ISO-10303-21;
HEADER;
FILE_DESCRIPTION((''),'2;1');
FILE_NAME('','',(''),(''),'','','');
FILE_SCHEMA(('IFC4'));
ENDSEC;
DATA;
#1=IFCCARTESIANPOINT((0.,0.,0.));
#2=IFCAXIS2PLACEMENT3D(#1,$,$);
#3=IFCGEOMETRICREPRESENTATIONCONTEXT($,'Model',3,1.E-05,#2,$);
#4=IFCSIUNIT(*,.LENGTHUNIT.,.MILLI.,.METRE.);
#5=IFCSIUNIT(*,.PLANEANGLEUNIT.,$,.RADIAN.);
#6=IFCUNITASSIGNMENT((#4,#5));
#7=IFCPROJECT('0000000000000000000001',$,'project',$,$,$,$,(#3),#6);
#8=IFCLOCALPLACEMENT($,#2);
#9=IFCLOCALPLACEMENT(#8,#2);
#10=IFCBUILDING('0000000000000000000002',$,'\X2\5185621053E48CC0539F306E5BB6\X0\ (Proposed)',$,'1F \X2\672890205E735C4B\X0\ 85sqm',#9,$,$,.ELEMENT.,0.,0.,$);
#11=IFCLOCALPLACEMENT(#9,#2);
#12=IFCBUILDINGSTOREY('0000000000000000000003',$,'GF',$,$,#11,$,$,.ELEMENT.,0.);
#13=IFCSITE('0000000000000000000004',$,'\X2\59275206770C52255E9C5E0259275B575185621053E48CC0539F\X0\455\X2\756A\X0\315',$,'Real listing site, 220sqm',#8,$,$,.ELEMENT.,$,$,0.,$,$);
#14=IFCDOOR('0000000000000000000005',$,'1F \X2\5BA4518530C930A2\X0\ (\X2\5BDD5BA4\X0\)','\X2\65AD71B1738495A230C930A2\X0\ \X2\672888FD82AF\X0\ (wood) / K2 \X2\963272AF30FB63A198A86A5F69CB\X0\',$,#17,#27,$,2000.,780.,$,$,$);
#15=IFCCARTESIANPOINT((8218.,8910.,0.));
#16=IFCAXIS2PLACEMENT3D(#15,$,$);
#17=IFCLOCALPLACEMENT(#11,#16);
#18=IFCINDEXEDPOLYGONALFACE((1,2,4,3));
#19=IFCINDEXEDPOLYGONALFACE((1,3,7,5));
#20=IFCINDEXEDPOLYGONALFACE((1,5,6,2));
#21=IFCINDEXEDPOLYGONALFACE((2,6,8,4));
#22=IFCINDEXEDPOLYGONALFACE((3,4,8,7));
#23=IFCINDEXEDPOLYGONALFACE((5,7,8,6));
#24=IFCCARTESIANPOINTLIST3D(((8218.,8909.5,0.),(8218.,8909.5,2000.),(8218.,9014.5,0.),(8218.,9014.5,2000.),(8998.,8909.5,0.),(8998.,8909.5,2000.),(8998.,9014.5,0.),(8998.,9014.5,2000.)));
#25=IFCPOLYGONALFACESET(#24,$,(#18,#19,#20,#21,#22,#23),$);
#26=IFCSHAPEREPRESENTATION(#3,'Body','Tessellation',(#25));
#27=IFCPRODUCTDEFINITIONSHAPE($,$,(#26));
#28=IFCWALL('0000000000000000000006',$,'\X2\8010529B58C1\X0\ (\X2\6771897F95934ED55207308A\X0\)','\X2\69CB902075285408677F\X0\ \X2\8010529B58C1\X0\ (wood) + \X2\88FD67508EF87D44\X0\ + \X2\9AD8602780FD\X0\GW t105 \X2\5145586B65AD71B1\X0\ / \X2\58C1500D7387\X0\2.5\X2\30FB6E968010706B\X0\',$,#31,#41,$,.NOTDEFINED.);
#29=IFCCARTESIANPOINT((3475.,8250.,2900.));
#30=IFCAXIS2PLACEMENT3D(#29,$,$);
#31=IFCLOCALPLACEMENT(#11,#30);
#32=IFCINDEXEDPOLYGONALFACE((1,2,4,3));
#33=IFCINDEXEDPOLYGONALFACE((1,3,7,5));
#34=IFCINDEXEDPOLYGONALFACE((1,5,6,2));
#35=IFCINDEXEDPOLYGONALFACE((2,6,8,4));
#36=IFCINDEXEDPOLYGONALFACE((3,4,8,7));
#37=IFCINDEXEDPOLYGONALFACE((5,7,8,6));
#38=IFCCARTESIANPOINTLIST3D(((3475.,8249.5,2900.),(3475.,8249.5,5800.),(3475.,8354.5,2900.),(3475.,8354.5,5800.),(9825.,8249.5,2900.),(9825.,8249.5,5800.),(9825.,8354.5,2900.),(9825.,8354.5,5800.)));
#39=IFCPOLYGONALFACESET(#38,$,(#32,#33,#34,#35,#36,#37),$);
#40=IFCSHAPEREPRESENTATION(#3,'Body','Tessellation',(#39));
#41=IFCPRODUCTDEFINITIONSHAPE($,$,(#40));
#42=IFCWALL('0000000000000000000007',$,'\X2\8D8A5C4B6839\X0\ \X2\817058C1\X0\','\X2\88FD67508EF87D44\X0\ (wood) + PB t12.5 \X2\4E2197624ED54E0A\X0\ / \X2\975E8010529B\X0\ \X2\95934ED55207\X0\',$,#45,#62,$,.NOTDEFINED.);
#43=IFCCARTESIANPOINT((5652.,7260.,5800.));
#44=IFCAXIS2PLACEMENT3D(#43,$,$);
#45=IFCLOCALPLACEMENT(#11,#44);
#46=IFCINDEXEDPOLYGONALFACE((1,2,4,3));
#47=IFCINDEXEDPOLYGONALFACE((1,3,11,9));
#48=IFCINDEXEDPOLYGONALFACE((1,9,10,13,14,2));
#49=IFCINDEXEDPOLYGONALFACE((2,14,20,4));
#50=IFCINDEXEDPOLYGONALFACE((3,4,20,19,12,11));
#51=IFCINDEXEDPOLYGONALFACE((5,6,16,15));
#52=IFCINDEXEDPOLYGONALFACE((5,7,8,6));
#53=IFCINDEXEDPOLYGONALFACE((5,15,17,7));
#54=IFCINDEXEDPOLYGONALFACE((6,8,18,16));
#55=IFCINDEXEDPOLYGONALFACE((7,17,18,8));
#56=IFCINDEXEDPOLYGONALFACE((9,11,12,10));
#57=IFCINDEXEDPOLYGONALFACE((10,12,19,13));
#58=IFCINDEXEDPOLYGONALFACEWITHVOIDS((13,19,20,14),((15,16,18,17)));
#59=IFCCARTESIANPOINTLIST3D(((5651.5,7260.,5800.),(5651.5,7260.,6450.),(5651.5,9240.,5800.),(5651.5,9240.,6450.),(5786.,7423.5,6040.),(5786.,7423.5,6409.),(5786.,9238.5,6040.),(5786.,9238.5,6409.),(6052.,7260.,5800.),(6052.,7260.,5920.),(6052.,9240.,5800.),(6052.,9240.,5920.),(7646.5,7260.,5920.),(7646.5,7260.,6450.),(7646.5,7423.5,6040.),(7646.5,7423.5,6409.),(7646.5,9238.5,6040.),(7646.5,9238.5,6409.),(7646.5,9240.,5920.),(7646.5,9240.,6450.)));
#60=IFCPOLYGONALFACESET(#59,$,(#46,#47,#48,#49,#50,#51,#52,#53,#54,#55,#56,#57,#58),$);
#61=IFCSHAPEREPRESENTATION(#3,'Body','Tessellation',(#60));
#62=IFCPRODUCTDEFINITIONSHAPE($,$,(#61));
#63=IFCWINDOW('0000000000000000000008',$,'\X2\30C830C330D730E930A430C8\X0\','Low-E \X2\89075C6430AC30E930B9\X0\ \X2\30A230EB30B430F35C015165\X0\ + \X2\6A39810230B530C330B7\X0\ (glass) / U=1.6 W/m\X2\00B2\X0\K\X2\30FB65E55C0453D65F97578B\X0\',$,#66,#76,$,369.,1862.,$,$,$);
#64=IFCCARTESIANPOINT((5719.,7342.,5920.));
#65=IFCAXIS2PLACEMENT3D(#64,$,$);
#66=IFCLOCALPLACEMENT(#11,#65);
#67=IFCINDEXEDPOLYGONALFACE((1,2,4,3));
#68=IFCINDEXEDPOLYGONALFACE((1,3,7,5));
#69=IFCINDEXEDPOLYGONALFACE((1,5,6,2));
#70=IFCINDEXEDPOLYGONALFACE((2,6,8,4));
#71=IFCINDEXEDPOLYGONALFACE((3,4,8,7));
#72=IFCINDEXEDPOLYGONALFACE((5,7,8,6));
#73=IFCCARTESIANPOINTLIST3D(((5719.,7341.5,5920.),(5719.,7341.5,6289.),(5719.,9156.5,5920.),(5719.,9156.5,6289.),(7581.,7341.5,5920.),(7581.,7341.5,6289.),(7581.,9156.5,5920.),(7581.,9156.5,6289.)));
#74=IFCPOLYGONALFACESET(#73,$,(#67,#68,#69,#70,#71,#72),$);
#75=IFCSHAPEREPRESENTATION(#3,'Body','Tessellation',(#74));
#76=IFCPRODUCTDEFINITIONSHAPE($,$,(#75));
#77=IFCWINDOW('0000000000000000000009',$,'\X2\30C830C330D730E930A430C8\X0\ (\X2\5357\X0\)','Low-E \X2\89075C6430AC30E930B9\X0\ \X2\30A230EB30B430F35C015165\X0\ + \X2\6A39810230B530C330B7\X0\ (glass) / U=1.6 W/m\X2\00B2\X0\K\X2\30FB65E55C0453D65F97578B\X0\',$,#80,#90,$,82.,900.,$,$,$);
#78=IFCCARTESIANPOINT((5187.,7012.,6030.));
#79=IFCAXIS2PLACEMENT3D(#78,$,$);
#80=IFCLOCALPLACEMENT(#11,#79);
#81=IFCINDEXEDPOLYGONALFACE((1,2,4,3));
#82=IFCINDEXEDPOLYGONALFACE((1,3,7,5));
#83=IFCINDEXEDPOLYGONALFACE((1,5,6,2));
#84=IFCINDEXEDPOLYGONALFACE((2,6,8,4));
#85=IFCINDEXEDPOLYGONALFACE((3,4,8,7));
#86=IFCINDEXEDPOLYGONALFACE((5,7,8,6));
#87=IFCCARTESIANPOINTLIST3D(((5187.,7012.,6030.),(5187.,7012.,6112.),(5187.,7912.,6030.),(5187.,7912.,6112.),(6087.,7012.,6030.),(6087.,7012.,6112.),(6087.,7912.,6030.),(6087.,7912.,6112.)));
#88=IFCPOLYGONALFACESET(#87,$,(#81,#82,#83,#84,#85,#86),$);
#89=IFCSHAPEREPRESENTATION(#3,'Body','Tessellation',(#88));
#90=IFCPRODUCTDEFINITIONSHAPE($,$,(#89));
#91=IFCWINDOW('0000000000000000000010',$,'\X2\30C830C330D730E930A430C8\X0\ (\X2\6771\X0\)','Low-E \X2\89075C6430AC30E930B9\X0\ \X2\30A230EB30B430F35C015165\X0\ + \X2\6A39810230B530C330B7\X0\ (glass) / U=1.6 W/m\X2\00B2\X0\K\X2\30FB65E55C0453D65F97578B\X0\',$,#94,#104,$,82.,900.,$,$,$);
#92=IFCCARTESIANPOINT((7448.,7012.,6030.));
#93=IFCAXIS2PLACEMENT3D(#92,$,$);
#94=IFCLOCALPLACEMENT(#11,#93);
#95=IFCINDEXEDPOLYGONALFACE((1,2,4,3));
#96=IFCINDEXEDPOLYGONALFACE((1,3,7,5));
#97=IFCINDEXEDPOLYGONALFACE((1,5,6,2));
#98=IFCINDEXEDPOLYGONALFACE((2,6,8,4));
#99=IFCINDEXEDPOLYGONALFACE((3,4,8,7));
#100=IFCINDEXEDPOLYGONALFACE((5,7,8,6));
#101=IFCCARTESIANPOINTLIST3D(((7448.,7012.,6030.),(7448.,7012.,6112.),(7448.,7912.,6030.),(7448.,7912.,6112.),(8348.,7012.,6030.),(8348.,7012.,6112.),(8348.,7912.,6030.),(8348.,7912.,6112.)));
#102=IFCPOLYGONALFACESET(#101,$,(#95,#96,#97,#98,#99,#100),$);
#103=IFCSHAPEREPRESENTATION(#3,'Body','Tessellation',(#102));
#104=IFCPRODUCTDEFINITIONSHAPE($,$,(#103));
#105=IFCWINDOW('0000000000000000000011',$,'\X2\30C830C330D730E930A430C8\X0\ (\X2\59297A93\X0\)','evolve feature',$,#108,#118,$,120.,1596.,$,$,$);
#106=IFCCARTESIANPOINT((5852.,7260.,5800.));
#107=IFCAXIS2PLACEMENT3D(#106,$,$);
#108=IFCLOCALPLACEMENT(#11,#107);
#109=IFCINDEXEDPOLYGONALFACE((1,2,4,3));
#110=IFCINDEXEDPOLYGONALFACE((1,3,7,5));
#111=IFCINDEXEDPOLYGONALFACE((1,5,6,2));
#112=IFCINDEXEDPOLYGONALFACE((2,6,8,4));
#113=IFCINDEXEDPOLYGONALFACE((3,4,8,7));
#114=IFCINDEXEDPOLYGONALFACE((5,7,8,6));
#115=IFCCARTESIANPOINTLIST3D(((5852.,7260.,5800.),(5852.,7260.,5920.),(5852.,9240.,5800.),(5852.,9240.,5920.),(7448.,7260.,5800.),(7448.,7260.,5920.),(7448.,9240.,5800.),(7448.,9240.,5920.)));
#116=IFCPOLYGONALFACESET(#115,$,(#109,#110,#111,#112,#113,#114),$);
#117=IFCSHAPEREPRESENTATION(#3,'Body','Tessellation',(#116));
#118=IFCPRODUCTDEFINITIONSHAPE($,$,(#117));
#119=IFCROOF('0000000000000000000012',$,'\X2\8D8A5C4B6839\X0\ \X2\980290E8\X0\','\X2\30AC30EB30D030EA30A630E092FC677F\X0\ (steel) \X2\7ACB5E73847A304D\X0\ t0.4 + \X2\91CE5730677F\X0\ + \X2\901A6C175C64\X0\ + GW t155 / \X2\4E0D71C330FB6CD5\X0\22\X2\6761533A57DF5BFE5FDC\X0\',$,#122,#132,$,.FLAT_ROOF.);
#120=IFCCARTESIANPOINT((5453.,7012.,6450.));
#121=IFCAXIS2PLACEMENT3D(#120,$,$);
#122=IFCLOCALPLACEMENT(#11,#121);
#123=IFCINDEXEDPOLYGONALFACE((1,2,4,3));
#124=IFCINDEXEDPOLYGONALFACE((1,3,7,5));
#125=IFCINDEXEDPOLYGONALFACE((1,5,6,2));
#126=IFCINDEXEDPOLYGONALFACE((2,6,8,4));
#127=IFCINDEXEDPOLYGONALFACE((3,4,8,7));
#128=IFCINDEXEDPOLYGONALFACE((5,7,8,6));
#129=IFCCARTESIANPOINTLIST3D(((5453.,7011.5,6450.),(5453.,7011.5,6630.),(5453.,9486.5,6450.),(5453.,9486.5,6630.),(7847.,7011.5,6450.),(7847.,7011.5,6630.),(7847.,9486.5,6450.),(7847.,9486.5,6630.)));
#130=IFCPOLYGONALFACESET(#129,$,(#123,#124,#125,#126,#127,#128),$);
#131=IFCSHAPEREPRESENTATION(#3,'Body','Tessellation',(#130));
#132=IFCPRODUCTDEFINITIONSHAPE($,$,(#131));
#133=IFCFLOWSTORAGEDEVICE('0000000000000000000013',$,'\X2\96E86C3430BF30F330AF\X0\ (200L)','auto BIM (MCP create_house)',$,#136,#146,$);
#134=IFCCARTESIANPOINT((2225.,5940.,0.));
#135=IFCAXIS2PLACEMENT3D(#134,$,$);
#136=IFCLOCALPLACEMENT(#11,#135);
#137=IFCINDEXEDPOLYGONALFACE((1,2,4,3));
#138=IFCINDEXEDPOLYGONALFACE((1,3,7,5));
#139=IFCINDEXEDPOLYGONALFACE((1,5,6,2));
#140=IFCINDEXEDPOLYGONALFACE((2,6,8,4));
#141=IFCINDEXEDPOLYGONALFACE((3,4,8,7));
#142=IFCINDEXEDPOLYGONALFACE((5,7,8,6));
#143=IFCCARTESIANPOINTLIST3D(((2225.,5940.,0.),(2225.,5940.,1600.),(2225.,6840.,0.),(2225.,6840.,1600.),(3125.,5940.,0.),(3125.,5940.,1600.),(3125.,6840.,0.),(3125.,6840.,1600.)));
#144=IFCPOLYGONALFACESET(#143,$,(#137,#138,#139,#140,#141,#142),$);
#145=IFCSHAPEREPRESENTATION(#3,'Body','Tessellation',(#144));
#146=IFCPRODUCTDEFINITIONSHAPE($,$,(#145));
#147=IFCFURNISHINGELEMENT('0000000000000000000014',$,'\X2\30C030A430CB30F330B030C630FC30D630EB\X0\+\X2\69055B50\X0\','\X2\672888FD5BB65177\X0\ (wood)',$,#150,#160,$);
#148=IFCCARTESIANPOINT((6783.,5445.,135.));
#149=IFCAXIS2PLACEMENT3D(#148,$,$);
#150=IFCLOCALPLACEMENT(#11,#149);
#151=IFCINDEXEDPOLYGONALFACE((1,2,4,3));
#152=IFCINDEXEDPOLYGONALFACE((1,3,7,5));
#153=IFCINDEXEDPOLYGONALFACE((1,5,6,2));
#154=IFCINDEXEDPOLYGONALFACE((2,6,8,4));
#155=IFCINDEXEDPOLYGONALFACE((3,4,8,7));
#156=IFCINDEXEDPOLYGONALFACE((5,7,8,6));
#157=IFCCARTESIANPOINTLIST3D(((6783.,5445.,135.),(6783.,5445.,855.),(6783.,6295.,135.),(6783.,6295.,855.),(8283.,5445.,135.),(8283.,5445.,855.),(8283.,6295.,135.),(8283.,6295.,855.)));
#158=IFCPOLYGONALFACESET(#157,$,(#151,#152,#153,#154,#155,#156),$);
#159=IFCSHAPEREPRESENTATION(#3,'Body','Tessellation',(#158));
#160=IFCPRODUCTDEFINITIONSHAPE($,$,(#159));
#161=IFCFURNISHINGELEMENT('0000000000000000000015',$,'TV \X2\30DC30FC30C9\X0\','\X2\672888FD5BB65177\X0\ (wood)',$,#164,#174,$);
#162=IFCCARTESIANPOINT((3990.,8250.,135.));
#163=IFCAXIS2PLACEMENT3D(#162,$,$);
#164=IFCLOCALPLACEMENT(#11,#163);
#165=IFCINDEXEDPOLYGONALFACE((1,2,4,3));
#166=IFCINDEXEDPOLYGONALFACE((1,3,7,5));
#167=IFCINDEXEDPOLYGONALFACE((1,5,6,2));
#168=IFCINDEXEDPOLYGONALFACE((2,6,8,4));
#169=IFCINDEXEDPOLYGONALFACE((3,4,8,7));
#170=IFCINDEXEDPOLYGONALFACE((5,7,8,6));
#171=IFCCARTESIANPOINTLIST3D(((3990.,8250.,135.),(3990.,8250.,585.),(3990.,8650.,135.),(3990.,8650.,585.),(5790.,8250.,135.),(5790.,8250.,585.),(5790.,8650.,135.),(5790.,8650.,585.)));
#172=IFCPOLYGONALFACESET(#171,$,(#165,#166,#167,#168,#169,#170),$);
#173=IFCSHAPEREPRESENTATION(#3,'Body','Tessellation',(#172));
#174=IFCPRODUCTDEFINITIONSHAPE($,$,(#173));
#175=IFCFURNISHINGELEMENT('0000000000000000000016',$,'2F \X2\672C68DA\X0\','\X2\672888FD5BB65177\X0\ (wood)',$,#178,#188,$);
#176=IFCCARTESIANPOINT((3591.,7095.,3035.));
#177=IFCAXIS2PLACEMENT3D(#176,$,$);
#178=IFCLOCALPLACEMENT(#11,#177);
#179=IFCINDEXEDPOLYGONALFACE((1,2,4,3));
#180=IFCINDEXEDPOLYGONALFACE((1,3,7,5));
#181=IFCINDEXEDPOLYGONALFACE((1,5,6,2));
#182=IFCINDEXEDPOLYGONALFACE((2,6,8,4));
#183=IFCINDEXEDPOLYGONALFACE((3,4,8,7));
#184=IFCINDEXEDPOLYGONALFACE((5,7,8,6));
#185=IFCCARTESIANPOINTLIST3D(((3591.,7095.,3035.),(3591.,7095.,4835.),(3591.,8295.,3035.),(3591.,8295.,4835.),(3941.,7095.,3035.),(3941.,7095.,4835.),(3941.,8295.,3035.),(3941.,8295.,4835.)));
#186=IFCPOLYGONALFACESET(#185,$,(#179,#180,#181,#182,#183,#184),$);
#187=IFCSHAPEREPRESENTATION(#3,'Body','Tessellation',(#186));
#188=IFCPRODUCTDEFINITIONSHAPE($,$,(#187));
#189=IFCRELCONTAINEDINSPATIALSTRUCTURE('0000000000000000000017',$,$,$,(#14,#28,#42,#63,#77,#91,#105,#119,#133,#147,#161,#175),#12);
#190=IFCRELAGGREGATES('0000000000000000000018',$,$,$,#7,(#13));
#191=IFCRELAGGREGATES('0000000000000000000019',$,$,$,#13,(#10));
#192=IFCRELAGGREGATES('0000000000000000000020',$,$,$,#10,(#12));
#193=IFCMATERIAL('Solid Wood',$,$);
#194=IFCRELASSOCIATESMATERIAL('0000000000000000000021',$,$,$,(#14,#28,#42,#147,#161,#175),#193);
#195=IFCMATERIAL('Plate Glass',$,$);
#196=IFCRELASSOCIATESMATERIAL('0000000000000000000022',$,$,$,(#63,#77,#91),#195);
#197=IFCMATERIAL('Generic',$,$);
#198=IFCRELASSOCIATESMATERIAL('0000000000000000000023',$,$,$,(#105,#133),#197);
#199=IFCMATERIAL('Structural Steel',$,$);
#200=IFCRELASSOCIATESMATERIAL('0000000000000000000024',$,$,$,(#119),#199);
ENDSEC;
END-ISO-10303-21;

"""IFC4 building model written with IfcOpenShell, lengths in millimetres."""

from ifc_helpers import new_model, si_unit, frame, frame_2d, origin, place, context, project, spatial, rectangle, extrude, material, element, fill, save


model = new_model("IFC4")

# Units and contexts
model_context = context("Model", 3, precision=1e-05, world=origin())
ifc_project = project(units=[si_unit("LENGTHUNIT", "METRE", prefix="MILLI"), si_unit("PLANEANGLEUNIT", "RADIAN")], contexts=[model_context])

# Site, building, storey
site_placement = place(None, origin())
site = spatial("IfcSite", under=ifc_project, at=site_placement, Name="大分県別府市大字内成古賀原455番315", ObjectType="Real listing site, 220sqm", CompositionType="ELEMENT", RefElevation=0.0)
building_placement = place(site_placement, origin())
building = spatial("IfcBuilding", under=site, at=building_placement, Name="内成古賀原の家 (Proposed)", ObjectType="1F 木造平屋 85sqm", CompositionType="ELEMENT", ElevationOfRefHeight=0.0, ElevationOfTerrain=0.0)
storey_placement = place(building_placement, origin())
storey = spatial("IfcBuildingStorey", under=building, at=storey_placement, Name="GF", CompositionType="ELEMENT", Elevation=0.0)

# Shared definitions
ifc_material_1 = material(Name="Solid Wood")

# Door
door_placement = place(storey_placement, frame((8218.0, 8910.0, 0.0)))
element("IfcDoor", 1, at=door_placement, inside=storey, material=ifc_material_1, Name="1F 室内ドア (寝室)", Description="断熱玄関ドア 木製芯 (wood) / K2 防犯・採風機構", OverallHeight=2000.0, OverallWidth=780.0, context=model_context, shape_type="SweptSolid", body=[
    extrude(rectangle(XDim=780.0, YDim=105.0, at=frame_2d((390.0, 52.0))), frame((8218.0, 8910.0, 0.0)), (0.0, 0.0, 1.0), 2000.0),
])

# Wall
wall_1_placement = place(storey_placement, frame((3475.0, 8250.0, 2900.0)))
element("IfcWall", 2, at=wall_1_placement, inside=storey, material=ifc_material_1, Name="耐力壁 (東西間仕切り)", Description="構造用合板 耐力壁 (wood) + 製材軸組 + 高性能GW t105 充填断熱 / 壁倍率2.5・準耐火", PredefinedType="NOTDEFINED", context=model_context, shape_type="SweptSolid", body=[
    extrude(rectangle(XDim=6350.0, YDim=105.0, at=frame_2d((3175.0, 52.0))), frame((3475.0, 8250.0, 2900.0)), (0.0, 0.0, 1.0), 2900.0),
])

# Wall, openings, windows
wall_2_placement = place(storey_placement, frame((5652.0, 7260.0, 5800.0)))
wall_2 = element("IfcWall", 3, at=wall_2_placement, inside=storey, material=ifc_material_1, Name="越屋根 腰壁", Description="製材軸組 (wood) + PB t12.5 両面仕上 / 非耐力 間仕切", PredefinedType="NOTDEFINED", context=model_context, shape_type="SweptSolid", body=[
    extrude(rectangle(XDim=1995.0, YDim=1980.0, at=frame_2d((997.0, 990.0))), frame((5652.0, 7260.0, 5800.0)), (0.0, 0.0, 1.0), 650.0),
])
opening_1_placement = place(storey_placement, frame((5719.0, 7342.0, 5920.0)))
opening_1 = element("IfcOpeningElement", 4, at=opening_1_placement, cuts=wall_2, PredefinedType="NOTDEFINED", context=model_context, shape_type="SweptSolid", body=[
    extrude(rectangle(XDim=1862.0, YDim=1815.0, at=frame_2d((931.0, 907.0))), frame((5719.0, 7342.0, 5920.0)), (0.0, 0.0, 1.0), 369.0),
])
opening_2_placement = place(storey_placement, frame((5187.0, 7012.0, 6030.0)))
opening_2 = element("IfcOpeningElement", 5, at=opening_2_placement, cuts=wall_2, PredefinedType="NOTDEFINED", context=model_context, shape_type="SweptSolid", body=[
    extrude(rectangle(XDim=900.0, YDim=900.0, at=frame_2d((450.0, 450.0))), frame((5187.0, 7012.0, 6030.0)), (0.0, 0.0, 1.0), 82.0),
])
opening_3_placement = place(storey_placement, frame((7448.0, 7012.0, 6030.0)))
opening_3 = element("IfcOpeningElement", 6, at=opening_3_placement, cuts=wall_2, PredefinedType="NOTDEFINED", context=model_context, shape_type="SweptSolid", body=[
    extrude(rectangle(XDim=900.0, YDim=900.0, at=frame_2d((450.0, 450.0))), frame((7448.0, 7012.0, 6030.0)), (0.0, 0.0, 1.0), 82.0),
])
opening_4_placement = place(storey_placement, frame((5852.0, 7260.0, 5800.0)))
opening_4 = element("IfcOpeningElement", 7, at=opening_4_placement, cuts=wall_2, PredefinedType="NOTDEFINED", context=model_context, shape_type="SweptSolid", body=[
    extrude(rectangle(XDim=1596.0, YDim=1980.0, at=frame_2d((798.0, 990.0))), frame((5852.0, 7260.0, 5800.0)), (0.0, 0.0, 1.0), 120.0),
])
ifc_material_2 = material(Name="Plate Glass")
window_1_placement = place(storey_placement, frame((5719.0, 7342.0, 5920.0)))
window_1 = element("IfcWindow", 8, at=window_1_placement, inside=storey, material=ifc_material_2, Name="トップライト", Description="Low-E 複層ガラス アルゴン封入 + 樹脂サッシ (glass) / U=1.6 W/m²K・日射取得型", OverallHeight=369.0, OverallWidth=1862.0, context=model_context, shape_type="SweptSolid", body=[
    extrude(rectangle(XDim=1862.0, YDim=1815.0, at=frame_2d((931.0, 907.0))), frame((5719.0, 7342.0, 5920.0)), (0.0, 0.0, 1.0), 369.0),
])
fill(opening_1, window_1)
window_2_placement = place(storey_placement, frame((5187.0, 7012.0, 6030.0)))
window_2 = element("IfcWindow", 9, at=window_2_placement, inside=storey, material=ifc_material_2, Name="トップライト (南)", Description="Low-E 複層ガラス アルゴン封入 + 樹脂サッシ (glass) / U=1.6 W/m²K・日射取得型", OverallHeight=82.0, OverallWidth=900.0, context=model_context, shape_type="SweptSolid", body=[
    extrude(rectangle(XDim=900.0, YDim=900.0, at=frame_2d((450.0, 450.0))), frame((5187.0, 7012.0, 6030.0)), (0.0, 0.0, 1.0), 82.0),
])
fill(opening_2, window_2)
window_3_placement = place(storey_placement, frame((7448.0, 7012.0, 6030.0)))
window_3 = element("IfcWindow", 10, at=window_3_placement, inside=storey, material=ifc_material_2, Name="トップライト (東)", Description="Low-E 複層ガラス アルゴン封入 + 樹脂サッシ (glass) / U=1.6 W/m²K・日射取得型", OverallHeight=82.0, OverallWidth=900.0, context=model_context, shape_type="SweptSolid", body=[
    extrude(rectangle(XDim=900.0, YDim=900.0, at=frame_2d((450.0, 450.0))), frame((7448.0, 7012.0, 6030.0)), (0.0, 0.0, 1.0), 82.0),
])
fill(opening_3, window_3)
ifc_material_3 = material(Name="Generic")
window_4_placement = place(storey_placement, frame((5852.0, 7260.0, 5800.0)))
window_4 = element("IfcWindow", 11, at=window_4_placement, inside=storey, material=ifc_material_3, Name="トップライト (天窓)", Description="evolve feature", OverallHeight=120.0, OverallWidth=1596.0, context=model_context, shape_type="SweptSolid", body=[
    extrude(rectangle(XDim=1596.0, YDim=1980.0, at=frame_2d((798.0, 990.0))), frame((5852.0, 7260.0, 5800.0)), (0.0, 0.0, 1.0), 120.0),
])
fill(opening_4, window_4)

# Roof
ifc_material_4 = material(Name="Structural Steel")
roof_placement = place(storey_placement, frame((5453.0, 7012.0, 6450.0)))
element("IfcRoof", 12, at=roof_placement, inside=storey, material=ifc_material_4, Name="越屋根 頂部", Description="ガルバリウム鋼板 (steel) 立平葺き t0.4 + 野地板 + 通気層 + GW t155 / 不燃・法22条区域対応", PredefinedType="FLAT_ROOF", context=model_context, shape_type="SweptSolid", body=[
    extrude(rectangle(XDim=2394.0, YDim=2475.0, at=frame_2d((1197.0, 1237.0))), frame((5453.0, 7012.0, 6450.0)), (0.0, 0.0, 1.0), 180.0),
])

# Flow storage device
flow_storage_device_placement = place(storey_placement, frame((2225.0, 5940.0, 0.0)))
element("IfcFlowStorageDevice", 13, at=flow_storage_device_placement, inside=storey, material=ifc_material_3, Name="雨水タンク (200L)", Description="auto BIM (MCP create_house)", context=model_context, shape_type="SweptSolid", body=[
    extrude(rectangle(XDim=900.0, YDim=900.0, at=frame_2d((450.0, 450.0))), frame((2225.0, 5940.0, 0.0)), (0.0, 0.0, 1.0), 1600.0),
])

# Furnishing elements
furnishing_1_placement = place(storey_placement, frame((6783.0, 5445.0, 135.0)))
element("IfcFurnishingElement", 14, at=furnishing_1_placement, inside=storey, material=ifc_material_1, Name="ダイニングテーブル+椅子", Description="木製家具 (wood)", context=model_context, shape_type="SweptSolid", body=[
    extrude(rectangle(XDim=1500.0, YDim=850.0, at=frame_2d((750.0, 425.0))), frame((6783.0, 5445.0, 135.0)), (0.0, 0.0, 1.0), 720.0),
])
furnishing_2_placement = place(storey_placement, frame((3990.0, 8250.0, 135.0)))
element("IfcFurnishingElement", 15, at=furnishing_2_placement, inside=storey, material=ifc_material_1, Name="TV ボード", Description="木製家具 (wood)", context=model_context, shape_type="SweptSolid", body=[
    extrude(rectangle(XDim=1800.0, YDim=400.0, at=frame_2d((900.0, 200.0))), frame((3990.0, 8250.0, 135.0)), (0.0, 0.0, 1.0), 450.0),
])
furnishing_3_placement = place(storey_placement, frame((3591.0, 7095.0, 3035.0)))
element("IfcFurnishingElement", 16, at=furnishing_3_placement, inside=storey, material=ifc_material_1, Name="2F 本棚", Description="木製家具 (wood)", context=model_context, shape_type="SweptSolid", body=[
    extrude(rectangle(XDim=350.0, YDim=1200.0, at=frame_2d((175.0, 600.0))), frame((3591.0, 7095.0, 3035.0)), (0.0, 0.0, 1.0), 1800.0),
])

save(model, "model.ifc")
